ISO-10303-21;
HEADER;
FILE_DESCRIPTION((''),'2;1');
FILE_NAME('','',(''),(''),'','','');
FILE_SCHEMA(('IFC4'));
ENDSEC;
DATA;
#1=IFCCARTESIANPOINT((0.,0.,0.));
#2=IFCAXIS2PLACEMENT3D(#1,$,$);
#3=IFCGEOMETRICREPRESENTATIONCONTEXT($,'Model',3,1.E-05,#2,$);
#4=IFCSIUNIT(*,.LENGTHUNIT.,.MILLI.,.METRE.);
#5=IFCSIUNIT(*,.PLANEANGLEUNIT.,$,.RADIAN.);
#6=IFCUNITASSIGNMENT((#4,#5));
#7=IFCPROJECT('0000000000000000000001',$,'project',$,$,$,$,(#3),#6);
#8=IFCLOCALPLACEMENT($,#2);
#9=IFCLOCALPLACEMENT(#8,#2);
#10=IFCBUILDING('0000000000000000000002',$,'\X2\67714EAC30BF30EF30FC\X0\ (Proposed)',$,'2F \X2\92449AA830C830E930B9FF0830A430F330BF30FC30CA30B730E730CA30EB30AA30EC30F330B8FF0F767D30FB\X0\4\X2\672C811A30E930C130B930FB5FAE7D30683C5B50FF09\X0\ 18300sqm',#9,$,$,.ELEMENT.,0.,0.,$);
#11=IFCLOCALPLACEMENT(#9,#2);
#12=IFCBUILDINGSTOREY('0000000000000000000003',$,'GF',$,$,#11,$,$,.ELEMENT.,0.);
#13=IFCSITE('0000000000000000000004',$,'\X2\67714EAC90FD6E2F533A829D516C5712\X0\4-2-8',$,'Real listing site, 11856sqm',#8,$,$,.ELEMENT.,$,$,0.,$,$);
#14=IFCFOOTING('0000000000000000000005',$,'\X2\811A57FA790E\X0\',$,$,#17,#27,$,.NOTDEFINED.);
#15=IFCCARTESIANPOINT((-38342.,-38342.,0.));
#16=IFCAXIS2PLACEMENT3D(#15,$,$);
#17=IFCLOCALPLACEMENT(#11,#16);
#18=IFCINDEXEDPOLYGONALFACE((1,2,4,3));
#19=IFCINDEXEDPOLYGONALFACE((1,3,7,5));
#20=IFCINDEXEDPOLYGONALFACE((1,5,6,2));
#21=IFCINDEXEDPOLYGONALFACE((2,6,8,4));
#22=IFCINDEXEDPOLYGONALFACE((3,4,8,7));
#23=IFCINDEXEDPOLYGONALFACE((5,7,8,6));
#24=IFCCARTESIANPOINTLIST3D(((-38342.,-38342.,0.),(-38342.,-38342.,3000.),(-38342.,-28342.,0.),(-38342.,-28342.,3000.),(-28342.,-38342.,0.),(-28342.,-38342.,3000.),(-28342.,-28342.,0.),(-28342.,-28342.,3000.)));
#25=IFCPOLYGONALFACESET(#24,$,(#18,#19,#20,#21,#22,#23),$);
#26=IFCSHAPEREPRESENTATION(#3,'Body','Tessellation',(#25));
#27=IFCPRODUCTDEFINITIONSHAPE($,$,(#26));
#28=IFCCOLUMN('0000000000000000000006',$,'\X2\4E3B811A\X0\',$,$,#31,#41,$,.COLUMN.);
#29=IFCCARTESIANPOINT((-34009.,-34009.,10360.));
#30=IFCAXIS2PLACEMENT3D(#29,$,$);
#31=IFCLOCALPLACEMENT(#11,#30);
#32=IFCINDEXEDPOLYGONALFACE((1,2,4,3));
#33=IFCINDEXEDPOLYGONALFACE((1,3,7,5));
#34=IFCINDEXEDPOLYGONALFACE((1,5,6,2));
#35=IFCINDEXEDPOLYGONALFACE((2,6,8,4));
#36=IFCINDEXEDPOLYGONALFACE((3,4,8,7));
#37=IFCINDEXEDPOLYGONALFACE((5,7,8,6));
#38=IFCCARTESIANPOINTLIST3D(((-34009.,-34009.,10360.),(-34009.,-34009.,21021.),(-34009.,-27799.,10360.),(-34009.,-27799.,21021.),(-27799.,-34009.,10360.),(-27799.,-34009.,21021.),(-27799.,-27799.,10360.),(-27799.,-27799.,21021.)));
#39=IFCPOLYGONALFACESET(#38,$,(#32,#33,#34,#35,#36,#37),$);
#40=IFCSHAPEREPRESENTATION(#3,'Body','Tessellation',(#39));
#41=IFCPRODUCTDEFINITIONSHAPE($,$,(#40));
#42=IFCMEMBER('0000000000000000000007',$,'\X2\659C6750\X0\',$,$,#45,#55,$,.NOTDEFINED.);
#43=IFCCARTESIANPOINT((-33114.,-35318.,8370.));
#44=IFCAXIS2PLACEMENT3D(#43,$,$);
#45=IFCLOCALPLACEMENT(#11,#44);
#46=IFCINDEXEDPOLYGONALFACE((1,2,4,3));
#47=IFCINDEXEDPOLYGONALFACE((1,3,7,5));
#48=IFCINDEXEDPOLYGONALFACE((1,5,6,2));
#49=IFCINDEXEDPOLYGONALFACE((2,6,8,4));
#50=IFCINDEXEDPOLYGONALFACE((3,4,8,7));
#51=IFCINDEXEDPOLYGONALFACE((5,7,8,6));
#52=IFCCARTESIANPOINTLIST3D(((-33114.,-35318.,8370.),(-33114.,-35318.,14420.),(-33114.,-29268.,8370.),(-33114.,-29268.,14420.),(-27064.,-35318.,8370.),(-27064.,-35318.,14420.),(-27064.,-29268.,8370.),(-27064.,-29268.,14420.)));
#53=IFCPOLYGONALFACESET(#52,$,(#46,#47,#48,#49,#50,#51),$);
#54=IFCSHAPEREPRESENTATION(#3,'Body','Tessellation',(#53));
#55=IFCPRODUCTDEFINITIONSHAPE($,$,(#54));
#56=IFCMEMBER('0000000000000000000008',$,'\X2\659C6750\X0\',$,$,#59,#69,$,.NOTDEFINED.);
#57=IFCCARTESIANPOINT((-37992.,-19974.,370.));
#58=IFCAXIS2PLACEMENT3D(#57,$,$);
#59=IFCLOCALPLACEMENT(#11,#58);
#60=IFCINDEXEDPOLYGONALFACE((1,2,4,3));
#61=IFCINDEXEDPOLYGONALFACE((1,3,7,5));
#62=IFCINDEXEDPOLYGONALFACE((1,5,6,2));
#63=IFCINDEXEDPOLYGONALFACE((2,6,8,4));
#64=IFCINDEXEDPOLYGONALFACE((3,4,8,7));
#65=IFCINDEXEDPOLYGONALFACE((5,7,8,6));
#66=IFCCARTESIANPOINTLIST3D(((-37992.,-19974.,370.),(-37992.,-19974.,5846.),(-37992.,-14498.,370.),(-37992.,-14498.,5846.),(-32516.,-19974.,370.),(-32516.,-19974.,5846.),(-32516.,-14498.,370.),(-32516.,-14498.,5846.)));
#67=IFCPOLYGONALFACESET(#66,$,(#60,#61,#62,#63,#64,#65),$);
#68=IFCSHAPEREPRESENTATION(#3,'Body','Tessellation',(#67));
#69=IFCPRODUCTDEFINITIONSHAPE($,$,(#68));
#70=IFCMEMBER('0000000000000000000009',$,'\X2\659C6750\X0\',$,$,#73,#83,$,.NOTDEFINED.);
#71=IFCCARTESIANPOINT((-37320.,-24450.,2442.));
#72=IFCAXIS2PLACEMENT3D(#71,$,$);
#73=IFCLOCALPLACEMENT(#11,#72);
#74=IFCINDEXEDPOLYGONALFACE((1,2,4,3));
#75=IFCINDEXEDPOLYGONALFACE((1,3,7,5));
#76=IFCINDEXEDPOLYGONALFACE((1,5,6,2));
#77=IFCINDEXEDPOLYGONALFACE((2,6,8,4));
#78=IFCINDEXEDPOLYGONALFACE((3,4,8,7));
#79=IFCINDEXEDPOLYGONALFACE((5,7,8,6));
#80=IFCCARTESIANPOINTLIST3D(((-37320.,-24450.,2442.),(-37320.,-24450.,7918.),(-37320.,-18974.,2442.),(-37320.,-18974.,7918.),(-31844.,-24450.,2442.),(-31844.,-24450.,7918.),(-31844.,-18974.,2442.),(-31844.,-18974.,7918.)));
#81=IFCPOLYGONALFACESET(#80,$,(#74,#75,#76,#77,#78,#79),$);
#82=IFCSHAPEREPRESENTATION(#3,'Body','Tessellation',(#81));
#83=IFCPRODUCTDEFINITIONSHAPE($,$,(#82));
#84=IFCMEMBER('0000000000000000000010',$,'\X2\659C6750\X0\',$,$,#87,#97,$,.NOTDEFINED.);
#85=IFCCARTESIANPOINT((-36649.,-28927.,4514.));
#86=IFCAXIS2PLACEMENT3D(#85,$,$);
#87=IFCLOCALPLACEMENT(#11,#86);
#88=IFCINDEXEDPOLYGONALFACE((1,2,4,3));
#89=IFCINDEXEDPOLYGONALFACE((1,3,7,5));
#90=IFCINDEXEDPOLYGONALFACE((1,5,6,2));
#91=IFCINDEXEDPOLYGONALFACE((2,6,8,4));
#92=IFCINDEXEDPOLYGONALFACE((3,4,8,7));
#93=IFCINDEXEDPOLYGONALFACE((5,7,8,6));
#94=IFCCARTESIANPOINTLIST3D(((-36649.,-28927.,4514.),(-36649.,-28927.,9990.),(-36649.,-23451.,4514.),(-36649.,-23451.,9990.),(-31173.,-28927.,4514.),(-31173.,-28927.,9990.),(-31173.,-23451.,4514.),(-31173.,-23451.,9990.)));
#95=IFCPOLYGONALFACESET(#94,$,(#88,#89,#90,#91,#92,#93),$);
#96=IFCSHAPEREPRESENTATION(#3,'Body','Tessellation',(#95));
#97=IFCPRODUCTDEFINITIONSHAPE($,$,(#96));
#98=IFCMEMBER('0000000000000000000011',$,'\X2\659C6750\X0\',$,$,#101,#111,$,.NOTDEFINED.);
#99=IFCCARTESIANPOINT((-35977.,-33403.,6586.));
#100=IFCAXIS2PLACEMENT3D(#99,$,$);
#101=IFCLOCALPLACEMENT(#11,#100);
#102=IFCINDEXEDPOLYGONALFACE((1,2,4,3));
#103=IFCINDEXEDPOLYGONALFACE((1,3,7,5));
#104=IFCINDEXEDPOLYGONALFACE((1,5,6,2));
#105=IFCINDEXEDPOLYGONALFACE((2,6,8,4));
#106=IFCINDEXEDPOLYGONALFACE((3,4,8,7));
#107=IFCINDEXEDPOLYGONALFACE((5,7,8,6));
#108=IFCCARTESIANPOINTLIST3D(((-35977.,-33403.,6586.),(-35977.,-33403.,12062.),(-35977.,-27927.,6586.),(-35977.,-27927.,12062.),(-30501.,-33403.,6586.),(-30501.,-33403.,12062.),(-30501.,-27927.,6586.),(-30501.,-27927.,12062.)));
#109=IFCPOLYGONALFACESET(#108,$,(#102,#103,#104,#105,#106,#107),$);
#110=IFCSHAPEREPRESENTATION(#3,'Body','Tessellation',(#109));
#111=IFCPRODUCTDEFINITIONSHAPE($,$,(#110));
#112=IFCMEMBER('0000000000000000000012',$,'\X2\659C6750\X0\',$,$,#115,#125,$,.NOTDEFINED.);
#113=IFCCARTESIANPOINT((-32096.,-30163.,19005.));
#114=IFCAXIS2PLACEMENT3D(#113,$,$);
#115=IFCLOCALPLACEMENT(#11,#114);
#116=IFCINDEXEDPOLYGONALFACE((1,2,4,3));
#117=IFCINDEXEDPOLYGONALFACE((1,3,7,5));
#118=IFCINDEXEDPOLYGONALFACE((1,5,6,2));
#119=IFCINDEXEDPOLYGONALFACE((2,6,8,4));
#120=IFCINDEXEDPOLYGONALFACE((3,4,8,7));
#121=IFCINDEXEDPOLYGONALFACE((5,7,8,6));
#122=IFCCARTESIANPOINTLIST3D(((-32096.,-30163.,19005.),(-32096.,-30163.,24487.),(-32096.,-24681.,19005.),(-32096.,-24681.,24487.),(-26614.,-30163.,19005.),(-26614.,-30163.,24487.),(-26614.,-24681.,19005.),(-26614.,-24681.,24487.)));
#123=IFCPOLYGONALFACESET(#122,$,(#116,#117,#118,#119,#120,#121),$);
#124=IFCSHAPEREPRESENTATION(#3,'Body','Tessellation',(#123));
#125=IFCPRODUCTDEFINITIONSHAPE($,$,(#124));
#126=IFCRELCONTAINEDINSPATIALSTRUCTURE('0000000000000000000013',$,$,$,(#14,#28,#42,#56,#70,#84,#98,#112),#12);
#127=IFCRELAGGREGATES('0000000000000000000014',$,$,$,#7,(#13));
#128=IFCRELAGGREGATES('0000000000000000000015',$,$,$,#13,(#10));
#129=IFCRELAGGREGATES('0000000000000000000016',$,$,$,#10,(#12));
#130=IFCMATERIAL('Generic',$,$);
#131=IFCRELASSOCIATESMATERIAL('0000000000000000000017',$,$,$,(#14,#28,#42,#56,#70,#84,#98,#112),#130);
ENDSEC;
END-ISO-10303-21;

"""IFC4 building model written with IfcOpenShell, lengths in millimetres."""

from ifc_helpers import new_model, si_unit, frame, frame_2d, origin, place, context, project, spatial, rectangle, extrude, material, element, save


model = new_model("IFC4")

# Units and contexts
model_context = context("Model", 3, precision=1e-05, world=origin())
ifc_project = project(units=[si_unit("LENGTHUNIT", "METRE", prefix="MILLI"), si_unit("PLANEANGLEUNIT", "RADIAN")], contexts=[model_context])

# Site, building, storey
site_placement = place(None, origin())
site = spatial("IfcSite", under=ifc_project, at=site_placement, Name="東京都港区芝公園4-2-8", ObjectType="Real listing site, 11856sqm", CompositionType="ELEMENT", RefElevation=0.0)
building_placement = place(site_placement, origin())
building = spatial("IfcBuilding", under=site, at=building_placement, Name="東京タワー (Proposed)", ObjectType="2F 鉄骨トラス（インターナショナルオレンジ／白・4本脚ラチス・微細格子） 18300sqm", CompositionType="ELEMENT", ElevationOfRefHeight=0.0, ElevationOfTerrain=0.0)
storey_placement = place(building_placement, origin())
storey = spatial("IfcBuildingStorey", under=building, at=storey_placement, Name="GF", CompositionType="ELEMENT", Elevation=0.0)

# Footing
ifc_material = material(Name="Generic")
footing_placement = place(storey_placement, frame((-38342.0, -38342.0, 0.0)))
element("IfcFooting", 1, at=footing_placement, inside=storey, material=ifc_material, Name="脚基礎", PredefinedType="NOTDEFINED", context=model_context, shape_type="SweptSolid", body=[
    extrude(rectangle(XDim=10000.0, YDim=10000.0, at=frame_2d((5000.0, 5000.0))), frame((-38342.0, -38342.0, 0.0)), (0.0, 0.0, 1.0), 3000.0),
])

# Column
column_1_placement = place(storey_placement, frame((-34009.0, -34009.0, 10360.0)))
element("IfcColumn", 2, at=column_1_placement, inside=storey, material=ifc_material, Name="主脚", PredefinedType="COLUMN", context=model_context, shape_type="SweptSolid", body=[
    extrude(rectangle(XDim=6210.0, YDim=6210.0, at=frame_2d((3105.0, 3105.0))), frame((-34009.0, -34009.0, 10360.0)), (0.0, 0.0, 1.0), 10661.0),
])

# Members
member_1_placement = place(storey_placement, frame((-33114.0, -35318.0, 8370.0)))
element("IfcMember", 3, at=member_1_placement, inside=storey, material=ifc_material, Name="斜材", PredefinedType="NOTDEFINED", context=model_context, shape_type="SweptSolid", body=[
    extrude(rectangle(XDim=6050.0, YDim=6050.0, at=frame_2d((3025.0, 3025.0))), frame((-33114.0, -35318.0, 8370.0)), (0.0, 0.0, 1.0), 6050.0),
])
member_2_placement = place(storey_placement, frame((-37992.0, -19974.0, 370.0)))
element("IfcMember", 4, at=member_2_placement, inside=storey, material=ifc_material, Name="斜材", PredefinedType="NOTDEFINED", context=model_context, shape_type="SweptSolid", body=[
    extrude(rectangle(XDim=5476.0, YDim=5476.0, at=frame_2d((2738.0, 2738.0))), frame((-37992.0, -19974.0, 370.0)), (0.0, 0.0, 1.0), 5476.0),
])
member_3_placement = place(storey_placement, frame((-37320.0, -24450.0, 2442.0)))
element("IfcMember", 5, at=member_3_placement, inside=storey, material=ifc_material, Name="斜材", PredefinedType="NOTDEFINED", context=model_context, shape_type="SweptSolid", body=[
    extrude(rectangle(XDim=5476.0, YDim=5476.0, at=frame_2d((2738.0, 2738.0))), frame((-37320.0, -24450.0, 2442.0)), (0.0, 0.0, 1.0), 5476.0),
])
member_4_placement = place(storey_placement, frame((-36649.0, -28927.0, 4514.0)))
element("IfcMember", 6, at=member_4_placement, inside=storey, material=ifc_material, Name="斜材", PredefinedType="NOTDEFINED", context=model_context, shape_type="SweptSolid", body=[
    extrude(rectangle(XDim=5476.0, YDim=5476.0, at=frame_2d((2738.0, 2738.0))), frame((-36649.0, -28927.0, 4514.0)), (0.0, 0.0, 1.0), 5476.0),
])
member_5_placement = place(storey_placement, frame((-35977.0, -33403.0, 6586.0)))
element("IfcMember", 7, at=member_5_placement, inside=storey, material=ifc_material, Name="斜材", PredefinedType="NOTDEFINED", context=model_context, shape_type="SweptSolid", body=[
    extrude(rectangle(XDim=5476.0, YDim=5476.0, at=frame_2d((2738.0, 2738.0))), frame((-35977.0, -33403.0, 6586.0)), (0.0, 0.0, 1.0), 5476.0),
])
member_6_placement = place(storey_placement, frame((-32096.0, -30163.0, 19005.0)))
element("IfcMember", 8, at=member_6_placement, inside=storey, material=ifc_material, Name="斜材", PredefinedType="NOTDEFINED", context=model_context, shape_type="SweptSolid", body=[
    extrude(rectangle(XDim=5482.0, YDim=5482.0, at=frame_2d((2741.0, 2741.0))), frame((-32096.0, -30163.0, 19005.0)), (0.0, 0.0, 1.0), 5482.0),
])

save(model, "model.ifc")
